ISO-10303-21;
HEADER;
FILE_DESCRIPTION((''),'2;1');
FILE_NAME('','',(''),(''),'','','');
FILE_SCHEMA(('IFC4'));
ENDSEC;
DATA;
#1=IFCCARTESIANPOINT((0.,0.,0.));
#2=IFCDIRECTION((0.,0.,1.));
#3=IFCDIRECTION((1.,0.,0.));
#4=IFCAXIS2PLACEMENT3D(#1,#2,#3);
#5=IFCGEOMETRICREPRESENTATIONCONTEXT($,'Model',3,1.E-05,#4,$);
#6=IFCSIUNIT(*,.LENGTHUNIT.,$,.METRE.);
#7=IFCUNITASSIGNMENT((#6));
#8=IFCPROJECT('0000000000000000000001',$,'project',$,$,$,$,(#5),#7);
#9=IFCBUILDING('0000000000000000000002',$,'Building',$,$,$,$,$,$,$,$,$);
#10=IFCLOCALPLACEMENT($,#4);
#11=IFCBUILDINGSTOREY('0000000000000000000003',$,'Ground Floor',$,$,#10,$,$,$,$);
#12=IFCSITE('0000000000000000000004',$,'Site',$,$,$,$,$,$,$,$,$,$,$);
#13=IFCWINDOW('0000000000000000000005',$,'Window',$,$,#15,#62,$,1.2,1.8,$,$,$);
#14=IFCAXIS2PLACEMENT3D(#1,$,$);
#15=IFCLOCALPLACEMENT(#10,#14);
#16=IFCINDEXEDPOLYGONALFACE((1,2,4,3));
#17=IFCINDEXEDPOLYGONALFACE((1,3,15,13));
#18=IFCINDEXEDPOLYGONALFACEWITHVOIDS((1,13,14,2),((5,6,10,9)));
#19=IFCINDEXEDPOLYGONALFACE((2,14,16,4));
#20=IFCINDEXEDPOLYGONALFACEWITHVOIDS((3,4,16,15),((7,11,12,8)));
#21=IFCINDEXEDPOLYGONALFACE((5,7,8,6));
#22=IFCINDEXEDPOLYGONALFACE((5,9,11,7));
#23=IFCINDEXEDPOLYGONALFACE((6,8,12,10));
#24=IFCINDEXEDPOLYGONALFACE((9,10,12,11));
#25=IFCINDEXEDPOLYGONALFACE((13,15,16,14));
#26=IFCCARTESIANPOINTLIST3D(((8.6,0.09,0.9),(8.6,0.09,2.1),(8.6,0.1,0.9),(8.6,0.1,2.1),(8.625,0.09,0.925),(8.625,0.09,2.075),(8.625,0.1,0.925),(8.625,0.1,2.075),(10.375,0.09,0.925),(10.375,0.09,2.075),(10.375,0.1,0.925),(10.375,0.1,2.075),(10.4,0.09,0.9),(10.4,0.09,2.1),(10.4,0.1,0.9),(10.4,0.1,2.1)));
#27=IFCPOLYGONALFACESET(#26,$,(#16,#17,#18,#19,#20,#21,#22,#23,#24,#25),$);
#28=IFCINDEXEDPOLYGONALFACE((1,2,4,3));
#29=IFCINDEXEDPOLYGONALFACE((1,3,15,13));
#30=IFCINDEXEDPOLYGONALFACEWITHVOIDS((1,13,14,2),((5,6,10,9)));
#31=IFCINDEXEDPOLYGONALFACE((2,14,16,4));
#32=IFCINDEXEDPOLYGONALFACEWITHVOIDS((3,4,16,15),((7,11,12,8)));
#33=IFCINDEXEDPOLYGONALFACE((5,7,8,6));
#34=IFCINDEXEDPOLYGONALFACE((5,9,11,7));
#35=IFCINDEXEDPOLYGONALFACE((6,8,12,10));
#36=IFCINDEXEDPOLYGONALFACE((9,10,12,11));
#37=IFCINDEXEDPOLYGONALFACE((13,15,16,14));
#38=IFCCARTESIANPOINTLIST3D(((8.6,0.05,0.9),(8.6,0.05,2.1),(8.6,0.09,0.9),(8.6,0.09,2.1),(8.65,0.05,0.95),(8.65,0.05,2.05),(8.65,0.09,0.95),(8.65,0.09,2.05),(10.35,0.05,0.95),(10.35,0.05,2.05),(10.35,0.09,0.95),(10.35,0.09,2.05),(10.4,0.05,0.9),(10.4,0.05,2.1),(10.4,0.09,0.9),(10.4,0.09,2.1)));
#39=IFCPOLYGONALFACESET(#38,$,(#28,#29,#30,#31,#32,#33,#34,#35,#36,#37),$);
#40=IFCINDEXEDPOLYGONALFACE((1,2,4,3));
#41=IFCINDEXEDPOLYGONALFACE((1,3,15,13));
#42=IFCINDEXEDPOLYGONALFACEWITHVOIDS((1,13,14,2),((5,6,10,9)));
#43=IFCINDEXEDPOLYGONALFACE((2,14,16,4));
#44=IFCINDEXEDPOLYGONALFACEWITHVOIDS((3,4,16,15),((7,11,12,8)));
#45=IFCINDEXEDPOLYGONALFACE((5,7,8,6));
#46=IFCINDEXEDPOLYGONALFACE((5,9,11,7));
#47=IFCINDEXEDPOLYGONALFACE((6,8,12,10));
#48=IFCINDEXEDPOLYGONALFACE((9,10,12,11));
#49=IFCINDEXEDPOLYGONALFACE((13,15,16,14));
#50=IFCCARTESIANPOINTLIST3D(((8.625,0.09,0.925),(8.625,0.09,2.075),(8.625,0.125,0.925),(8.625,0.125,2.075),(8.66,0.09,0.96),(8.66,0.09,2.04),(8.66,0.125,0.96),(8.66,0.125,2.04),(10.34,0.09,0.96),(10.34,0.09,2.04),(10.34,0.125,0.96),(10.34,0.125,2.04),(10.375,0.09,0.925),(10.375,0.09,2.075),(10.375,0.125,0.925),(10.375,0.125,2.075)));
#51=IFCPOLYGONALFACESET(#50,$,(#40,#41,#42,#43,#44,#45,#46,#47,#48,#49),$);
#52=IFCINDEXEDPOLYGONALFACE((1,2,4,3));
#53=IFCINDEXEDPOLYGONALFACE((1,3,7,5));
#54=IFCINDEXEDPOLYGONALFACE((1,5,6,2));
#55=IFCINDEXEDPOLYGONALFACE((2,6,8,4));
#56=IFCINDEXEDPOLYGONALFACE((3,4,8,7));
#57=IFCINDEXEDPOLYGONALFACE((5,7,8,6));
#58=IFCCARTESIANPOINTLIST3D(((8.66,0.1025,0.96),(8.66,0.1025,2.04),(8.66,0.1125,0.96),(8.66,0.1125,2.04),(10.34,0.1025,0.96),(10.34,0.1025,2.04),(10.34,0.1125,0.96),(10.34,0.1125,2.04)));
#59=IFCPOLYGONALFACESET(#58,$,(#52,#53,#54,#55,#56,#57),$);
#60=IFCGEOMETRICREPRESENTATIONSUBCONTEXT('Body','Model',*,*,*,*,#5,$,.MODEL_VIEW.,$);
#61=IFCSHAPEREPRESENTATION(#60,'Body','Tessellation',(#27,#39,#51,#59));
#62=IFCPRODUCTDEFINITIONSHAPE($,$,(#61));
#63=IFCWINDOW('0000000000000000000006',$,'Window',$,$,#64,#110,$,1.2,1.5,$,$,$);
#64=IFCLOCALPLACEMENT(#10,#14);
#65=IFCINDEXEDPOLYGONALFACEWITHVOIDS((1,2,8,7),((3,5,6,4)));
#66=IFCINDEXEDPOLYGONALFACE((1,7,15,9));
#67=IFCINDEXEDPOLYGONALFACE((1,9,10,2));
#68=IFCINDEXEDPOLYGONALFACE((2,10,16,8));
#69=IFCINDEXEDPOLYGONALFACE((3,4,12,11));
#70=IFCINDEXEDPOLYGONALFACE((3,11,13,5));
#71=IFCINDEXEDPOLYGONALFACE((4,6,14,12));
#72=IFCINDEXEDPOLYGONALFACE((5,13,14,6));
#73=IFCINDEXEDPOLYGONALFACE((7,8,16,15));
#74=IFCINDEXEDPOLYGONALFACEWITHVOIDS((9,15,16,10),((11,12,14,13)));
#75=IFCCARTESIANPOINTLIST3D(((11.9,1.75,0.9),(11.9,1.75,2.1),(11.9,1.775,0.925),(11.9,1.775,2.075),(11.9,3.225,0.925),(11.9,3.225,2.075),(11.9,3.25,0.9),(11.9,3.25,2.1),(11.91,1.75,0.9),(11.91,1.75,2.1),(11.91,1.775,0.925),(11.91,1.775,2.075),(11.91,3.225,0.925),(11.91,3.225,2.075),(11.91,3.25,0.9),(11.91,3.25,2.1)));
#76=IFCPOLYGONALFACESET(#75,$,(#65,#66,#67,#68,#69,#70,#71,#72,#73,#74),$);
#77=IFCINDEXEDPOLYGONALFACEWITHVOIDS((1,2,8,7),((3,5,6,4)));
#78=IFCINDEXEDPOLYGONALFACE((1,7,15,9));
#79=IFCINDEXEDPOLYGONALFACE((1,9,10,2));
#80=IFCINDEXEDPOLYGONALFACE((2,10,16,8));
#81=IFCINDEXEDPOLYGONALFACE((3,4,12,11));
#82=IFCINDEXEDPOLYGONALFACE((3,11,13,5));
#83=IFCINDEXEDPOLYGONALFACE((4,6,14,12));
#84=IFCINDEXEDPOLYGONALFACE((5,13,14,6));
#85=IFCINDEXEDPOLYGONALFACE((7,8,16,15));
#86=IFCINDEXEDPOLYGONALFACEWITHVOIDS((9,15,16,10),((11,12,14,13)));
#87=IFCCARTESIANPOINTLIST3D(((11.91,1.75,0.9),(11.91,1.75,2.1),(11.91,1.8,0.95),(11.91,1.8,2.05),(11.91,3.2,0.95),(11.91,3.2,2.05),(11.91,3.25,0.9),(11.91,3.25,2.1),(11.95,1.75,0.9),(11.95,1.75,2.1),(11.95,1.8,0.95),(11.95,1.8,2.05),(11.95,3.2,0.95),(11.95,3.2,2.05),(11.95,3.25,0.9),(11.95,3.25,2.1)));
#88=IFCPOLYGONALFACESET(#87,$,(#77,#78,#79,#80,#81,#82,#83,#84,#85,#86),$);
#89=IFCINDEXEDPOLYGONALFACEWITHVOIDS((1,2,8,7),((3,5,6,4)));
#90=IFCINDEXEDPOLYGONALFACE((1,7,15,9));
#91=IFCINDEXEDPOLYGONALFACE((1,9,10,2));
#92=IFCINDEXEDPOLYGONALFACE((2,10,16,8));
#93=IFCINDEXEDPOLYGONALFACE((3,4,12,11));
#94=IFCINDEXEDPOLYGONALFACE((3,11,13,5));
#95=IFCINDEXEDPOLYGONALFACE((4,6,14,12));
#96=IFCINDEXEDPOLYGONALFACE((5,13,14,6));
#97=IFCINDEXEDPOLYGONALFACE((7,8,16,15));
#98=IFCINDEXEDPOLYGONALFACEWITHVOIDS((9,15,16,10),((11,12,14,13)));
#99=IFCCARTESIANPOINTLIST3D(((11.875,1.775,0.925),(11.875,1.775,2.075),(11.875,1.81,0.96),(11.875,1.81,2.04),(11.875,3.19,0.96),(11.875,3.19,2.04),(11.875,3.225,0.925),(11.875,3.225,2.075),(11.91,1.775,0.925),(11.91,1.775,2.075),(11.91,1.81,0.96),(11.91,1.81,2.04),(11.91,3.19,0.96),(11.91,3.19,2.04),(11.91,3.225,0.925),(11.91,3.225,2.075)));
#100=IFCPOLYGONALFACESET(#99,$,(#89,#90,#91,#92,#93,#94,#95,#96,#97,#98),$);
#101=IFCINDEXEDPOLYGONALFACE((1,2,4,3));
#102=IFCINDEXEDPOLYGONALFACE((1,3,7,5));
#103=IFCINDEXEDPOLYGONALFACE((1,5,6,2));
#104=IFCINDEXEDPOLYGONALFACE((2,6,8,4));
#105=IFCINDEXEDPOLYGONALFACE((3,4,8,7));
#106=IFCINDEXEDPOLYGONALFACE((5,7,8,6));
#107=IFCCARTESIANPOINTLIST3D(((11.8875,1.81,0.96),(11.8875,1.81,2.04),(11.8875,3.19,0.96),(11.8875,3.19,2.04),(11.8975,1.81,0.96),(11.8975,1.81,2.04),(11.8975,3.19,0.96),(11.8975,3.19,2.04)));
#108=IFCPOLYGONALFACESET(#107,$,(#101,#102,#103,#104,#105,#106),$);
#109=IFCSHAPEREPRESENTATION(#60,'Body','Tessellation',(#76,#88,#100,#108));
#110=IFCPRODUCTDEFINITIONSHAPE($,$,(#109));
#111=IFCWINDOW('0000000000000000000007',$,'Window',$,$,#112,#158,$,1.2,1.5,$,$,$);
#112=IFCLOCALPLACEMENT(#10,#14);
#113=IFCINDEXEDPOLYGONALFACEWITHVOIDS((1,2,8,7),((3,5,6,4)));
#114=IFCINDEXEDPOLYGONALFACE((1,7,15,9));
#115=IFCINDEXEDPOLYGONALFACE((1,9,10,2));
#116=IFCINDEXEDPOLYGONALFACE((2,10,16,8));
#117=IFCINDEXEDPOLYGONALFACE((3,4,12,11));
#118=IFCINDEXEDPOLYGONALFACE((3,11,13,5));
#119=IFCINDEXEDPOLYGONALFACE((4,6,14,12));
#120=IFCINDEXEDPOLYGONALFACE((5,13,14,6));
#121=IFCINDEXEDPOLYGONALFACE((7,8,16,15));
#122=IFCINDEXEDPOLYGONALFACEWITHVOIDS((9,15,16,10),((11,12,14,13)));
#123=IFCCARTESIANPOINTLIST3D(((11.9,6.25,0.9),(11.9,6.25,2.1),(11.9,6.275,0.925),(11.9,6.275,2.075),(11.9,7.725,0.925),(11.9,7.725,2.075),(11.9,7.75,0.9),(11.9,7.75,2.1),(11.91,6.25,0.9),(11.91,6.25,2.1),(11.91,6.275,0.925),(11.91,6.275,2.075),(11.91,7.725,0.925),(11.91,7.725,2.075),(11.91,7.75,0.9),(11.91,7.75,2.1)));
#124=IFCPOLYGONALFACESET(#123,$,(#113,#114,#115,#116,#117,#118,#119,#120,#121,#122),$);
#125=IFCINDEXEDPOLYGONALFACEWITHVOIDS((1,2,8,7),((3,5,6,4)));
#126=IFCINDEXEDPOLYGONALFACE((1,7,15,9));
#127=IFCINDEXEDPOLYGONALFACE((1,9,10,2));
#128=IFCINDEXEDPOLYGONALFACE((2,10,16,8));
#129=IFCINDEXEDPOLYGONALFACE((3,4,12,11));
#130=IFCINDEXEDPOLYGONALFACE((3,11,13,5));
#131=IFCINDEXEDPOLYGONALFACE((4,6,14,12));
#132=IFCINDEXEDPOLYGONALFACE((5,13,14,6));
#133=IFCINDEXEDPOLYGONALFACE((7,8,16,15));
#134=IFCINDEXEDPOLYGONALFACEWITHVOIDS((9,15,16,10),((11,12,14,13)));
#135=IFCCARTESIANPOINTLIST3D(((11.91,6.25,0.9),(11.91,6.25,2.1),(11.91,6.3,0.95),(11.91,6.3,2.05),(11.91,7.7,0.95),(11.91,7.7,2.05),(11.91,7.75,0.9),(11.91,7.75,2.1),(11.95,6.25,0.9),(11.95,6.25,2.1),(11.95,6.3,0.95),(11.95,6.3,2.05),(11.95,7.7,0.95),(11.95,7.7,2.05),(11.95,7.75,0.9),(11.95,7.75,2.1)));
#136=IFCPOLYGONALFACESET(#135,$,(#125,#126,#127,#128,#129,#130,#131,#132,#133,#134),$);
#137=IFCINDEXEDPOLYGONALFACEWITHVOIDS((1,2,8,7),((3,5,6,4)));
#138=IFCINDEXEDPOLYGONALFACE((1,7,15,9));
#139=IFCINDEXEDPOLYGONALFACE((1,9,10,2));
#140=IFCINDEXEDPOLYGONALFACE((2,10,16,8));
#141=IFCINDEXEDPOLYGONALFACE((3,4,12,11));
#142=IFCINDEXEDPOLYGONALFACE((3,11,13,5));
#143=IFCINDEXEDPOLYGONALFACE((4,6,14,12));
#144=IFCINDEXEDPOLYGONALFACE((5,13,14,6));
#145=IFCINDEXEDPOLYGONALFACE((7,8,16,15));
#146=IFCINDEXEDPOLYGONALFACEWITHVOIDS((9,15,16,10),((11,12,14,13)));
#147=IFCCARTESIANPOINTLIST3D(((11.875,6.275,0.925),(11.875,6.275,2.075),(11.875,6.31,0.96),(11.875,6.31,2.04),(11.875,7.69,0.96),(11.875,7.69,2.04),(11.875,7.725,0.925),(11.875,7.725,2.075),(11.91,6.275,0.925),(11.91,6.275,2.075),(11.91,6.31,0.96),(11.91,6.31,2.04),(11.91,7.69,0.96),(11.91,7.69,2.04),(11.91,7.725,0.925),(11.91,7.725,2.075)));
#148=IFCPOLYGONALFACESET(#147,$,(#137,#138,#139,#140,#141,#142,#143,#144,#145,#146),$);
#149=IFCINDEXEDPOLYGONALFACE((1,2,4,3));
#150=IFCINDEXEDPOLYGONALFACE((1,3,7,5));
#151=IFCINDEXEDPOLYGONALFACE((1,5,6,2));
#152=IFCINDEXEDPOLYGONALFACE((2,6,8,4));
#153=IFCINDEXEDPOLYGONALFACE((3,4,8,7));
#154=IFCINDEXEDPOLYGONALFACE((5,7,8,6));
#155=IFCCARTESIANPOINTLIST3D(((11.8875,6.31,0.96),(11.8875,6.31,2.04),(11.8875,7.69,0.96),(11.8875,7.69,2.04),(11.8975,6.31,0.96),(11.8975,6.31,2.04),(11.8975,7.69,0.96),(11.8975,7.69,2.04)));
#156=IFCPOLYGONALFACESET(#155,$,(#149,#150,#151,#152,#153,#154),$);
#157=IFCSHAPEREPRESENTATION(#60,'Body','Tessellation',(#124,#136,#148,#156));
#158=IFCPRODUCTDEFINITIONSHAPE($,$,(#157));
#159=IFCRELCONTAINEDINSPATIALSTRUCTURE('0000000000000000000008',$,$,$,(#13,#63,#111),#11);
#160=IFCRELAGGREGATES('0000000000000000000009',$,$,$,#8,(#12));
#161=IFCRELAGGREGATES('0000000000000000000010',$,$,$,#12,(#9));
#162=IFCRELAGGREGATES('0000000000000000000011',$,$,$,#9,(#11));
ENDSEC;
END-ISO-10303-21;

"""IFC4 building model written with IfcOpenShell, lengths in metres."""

from ifc_helpers import new_model, si_unit, frame, origin_with_axes, place, context, subcontext, project, spatial, line, indexed_curve, outline, extrude, element, save


model = new_model("IFC4")

# Units and contexts
model_context = context("Model", 3, precision=1e-05, world=origin_with_axes())
body_context = subcontext(model_context, "Body", "Model", "MODEL_VIEW")
ifc_project = project(units=[si_unit("LENGTHUNIT", "METRE")], contexts=[model_context])

# Site, building, storey
site = spatial("IfcSite", under=ifc_project, Name="Site")
building = spatial("IfcBuilding", under=site, Name="Building")
storey_placement = place(None, origin_with_axes())
storey = spatial("IfcBuildingStorey", under=building, at=storey_placement, Name="Ground Floor")

# Windows
window_placement = place(storey_placement, frame((8.6, 0.0, 0.9), z_axis=(0.0, 0.0, 1.0), x_axis=(1.0, 0.0, 0.0)))
element("IfcWindow", 1, at=window_placement, inside=storey, Name="Window", OverallHeight=1.2, OverallWidth=1.8, context=body_context, shape_type="SweptSolid", body=[
    extrude(outline(indexed_curve([(0.0, 0.0), (1.8, 0.0), (1.8, 1.2), (0.0, 1.2)], segments=[line(1, 2, 3, 4, 1)]), holes=[indexed_curve([(0.025, 0.025), (1.775, 0.025), (1.775, 1.175), (0.025, 1.175)], segments=[line(1, 2, 3, 4, 1)])]), frame((0.0, 0.09, 0.0), z_axis=(0.0, -1.0, 0.0), x_axis=(1.0, 0.0, 0.0)), (0.0, 0.0, -1.0), 0.01),
    extrude(outline(indexed_curve([(0.0, 0.0), (1.8, 0.0), (1.8, 1.2), (0.0, 1.2)], segments=[line(1, 2, 3, 4, 1)]), holes=[indexed_curve([(0.05, 0.05), (1.75, 0.05), (1.75, 1.15), (0.05, 1.15)], segments=[line(1, 2, 3, 4, 1)])]), frame((0.0, 0.05, 0.0), z_axis=(0.0, -1.0, 0.0), x_axis=(1.0, 0.0, 0.0)), (0.0, 0.0, -1.0), 0.04),
    extrude(outline(indexed_curve([(0.0, 0.0), (1.75, 0.0), (1.75, 1.15), (0.0, 1.15)], segments=[line(1, 2, 3, 4, 1)]), holes=[indexed_curve([(0.035, 0.035), (1.715, 0.035), (1.715, 1.115), (0.035, 1.115)], segments=[line(1, 2, 3, 4, 1)])]), frame((0.025, 0.09, 0.025), z_axis=(0.0, -1.0, 0.0), x_axis=(1.0, 0.0, 0.0)), (0.0, 0.0, -1.0), 0.035),
    extrude(outline(indexed_curve([(0.035, 0.035), (1.715, 0.035), (1.715, 1.115), (0.035, 1.115)], segments=[line(1, 2, 3, 4, 1)])), frame((0.025, 0.1025, 0.025), z_axis=(0.0, -1.0, 0.0), x_axis=(1.0, 0.0, 0.0)), (0.0, 0.0, -1.0), 0.01),
])
for number, where, z_axis, x_axis, name in (
    (2, (12.0, 1.75, 0.9), (0.0, 0.0, 1.0), (0.0, 1.0, 0.0), "Window"),
    (3, (12.0, 6.25, 0.9), (0.0, 0.0, 1.0), (0.0, 1.0, 0.0), "Window"),
):
    element("IfcWindow", number, at=place(storey_placement, frame(where, z_axis=z_axis, x_axis=x_axis)), inside=storey, Name=name, OverallHeight=1.2, OverallWidth=1.5, context=body_context, shape_type="SweptSolid", body=[
        extrude(outline(indexed_curve([(0.0, 0.0), (1.5, 0.0), (1.5, 1.2), (0.0, 1.2)], segments=[line(1, 2, 3, 4, 1)]), holes=[indexed_curve([(0.025, 0.025), (1.475, 0.025), (1.475, 1.175), (0.025, 1.175)], segments=[line(1, 2, 3, 4, 1)])]), frame((0.0, 0.09, 0.0), z_axis=(0.0, -1.0, 0.0), x_axis=(1.0, 0.0, 0.0)), (0.0, 0.0, -1.0), 0.01),
        extrude(outline(indexed_curve([(0.0, 0.0), (1.5, 0.0), (1.5, 1.2), (0.0, 1.2)], segments=[line(1, 2, 3, 4, 1)]), holes=[indexed_curve([(0.05, 0.05), (1.45, 0.05), (1.45, 1.15), (0.05, 1.15)], segments=[line(1, 2, 3, 4, 1)])]), frame((0.0, 0.05, 0.0), z_axis=(0.0, -1.0, 0.0), x_axis=(1.0, 0.0, 0.0)), (0.0, 0.0, -1.0), 0.04),
        extrude(outline(indexed_curve([(0.0, 0.0), (1.45, 0.0), (1.45, 1.15), (0.0, 1.15)], segments=[line(1, 2, 3, 4, 1)]), holes=[indexed_curve([(0.035, 0.035), (1.415, 0.035), (1.415, 1.115), (0.035, 1.115)], segments=[line(1, 2, 3, 4, 1)])]), frame((0.025, 0.09, 0.025), z_axis=(0.0, -1.0, 0.0), x_axis=(1.0, 0.0, 0.0)), (0.0, 0.0, -1.0), 0.035),
        extrude(outline(indexed_curve([(0.035, 0.035), (1.415, 0.035), (1.415, 1.115), (0.035, 1.115)], segments=[line(1, 2, 3, 4, 1)])), frame((0.025, 0.1025, 0.025), z_axis=(0.0, -1.0, 0.0), x_axis=(1.0, 0.0, 0.0)), (0.0, 0.0, -1.0), 0.01),
    ])

save(model, "model.ifc")
